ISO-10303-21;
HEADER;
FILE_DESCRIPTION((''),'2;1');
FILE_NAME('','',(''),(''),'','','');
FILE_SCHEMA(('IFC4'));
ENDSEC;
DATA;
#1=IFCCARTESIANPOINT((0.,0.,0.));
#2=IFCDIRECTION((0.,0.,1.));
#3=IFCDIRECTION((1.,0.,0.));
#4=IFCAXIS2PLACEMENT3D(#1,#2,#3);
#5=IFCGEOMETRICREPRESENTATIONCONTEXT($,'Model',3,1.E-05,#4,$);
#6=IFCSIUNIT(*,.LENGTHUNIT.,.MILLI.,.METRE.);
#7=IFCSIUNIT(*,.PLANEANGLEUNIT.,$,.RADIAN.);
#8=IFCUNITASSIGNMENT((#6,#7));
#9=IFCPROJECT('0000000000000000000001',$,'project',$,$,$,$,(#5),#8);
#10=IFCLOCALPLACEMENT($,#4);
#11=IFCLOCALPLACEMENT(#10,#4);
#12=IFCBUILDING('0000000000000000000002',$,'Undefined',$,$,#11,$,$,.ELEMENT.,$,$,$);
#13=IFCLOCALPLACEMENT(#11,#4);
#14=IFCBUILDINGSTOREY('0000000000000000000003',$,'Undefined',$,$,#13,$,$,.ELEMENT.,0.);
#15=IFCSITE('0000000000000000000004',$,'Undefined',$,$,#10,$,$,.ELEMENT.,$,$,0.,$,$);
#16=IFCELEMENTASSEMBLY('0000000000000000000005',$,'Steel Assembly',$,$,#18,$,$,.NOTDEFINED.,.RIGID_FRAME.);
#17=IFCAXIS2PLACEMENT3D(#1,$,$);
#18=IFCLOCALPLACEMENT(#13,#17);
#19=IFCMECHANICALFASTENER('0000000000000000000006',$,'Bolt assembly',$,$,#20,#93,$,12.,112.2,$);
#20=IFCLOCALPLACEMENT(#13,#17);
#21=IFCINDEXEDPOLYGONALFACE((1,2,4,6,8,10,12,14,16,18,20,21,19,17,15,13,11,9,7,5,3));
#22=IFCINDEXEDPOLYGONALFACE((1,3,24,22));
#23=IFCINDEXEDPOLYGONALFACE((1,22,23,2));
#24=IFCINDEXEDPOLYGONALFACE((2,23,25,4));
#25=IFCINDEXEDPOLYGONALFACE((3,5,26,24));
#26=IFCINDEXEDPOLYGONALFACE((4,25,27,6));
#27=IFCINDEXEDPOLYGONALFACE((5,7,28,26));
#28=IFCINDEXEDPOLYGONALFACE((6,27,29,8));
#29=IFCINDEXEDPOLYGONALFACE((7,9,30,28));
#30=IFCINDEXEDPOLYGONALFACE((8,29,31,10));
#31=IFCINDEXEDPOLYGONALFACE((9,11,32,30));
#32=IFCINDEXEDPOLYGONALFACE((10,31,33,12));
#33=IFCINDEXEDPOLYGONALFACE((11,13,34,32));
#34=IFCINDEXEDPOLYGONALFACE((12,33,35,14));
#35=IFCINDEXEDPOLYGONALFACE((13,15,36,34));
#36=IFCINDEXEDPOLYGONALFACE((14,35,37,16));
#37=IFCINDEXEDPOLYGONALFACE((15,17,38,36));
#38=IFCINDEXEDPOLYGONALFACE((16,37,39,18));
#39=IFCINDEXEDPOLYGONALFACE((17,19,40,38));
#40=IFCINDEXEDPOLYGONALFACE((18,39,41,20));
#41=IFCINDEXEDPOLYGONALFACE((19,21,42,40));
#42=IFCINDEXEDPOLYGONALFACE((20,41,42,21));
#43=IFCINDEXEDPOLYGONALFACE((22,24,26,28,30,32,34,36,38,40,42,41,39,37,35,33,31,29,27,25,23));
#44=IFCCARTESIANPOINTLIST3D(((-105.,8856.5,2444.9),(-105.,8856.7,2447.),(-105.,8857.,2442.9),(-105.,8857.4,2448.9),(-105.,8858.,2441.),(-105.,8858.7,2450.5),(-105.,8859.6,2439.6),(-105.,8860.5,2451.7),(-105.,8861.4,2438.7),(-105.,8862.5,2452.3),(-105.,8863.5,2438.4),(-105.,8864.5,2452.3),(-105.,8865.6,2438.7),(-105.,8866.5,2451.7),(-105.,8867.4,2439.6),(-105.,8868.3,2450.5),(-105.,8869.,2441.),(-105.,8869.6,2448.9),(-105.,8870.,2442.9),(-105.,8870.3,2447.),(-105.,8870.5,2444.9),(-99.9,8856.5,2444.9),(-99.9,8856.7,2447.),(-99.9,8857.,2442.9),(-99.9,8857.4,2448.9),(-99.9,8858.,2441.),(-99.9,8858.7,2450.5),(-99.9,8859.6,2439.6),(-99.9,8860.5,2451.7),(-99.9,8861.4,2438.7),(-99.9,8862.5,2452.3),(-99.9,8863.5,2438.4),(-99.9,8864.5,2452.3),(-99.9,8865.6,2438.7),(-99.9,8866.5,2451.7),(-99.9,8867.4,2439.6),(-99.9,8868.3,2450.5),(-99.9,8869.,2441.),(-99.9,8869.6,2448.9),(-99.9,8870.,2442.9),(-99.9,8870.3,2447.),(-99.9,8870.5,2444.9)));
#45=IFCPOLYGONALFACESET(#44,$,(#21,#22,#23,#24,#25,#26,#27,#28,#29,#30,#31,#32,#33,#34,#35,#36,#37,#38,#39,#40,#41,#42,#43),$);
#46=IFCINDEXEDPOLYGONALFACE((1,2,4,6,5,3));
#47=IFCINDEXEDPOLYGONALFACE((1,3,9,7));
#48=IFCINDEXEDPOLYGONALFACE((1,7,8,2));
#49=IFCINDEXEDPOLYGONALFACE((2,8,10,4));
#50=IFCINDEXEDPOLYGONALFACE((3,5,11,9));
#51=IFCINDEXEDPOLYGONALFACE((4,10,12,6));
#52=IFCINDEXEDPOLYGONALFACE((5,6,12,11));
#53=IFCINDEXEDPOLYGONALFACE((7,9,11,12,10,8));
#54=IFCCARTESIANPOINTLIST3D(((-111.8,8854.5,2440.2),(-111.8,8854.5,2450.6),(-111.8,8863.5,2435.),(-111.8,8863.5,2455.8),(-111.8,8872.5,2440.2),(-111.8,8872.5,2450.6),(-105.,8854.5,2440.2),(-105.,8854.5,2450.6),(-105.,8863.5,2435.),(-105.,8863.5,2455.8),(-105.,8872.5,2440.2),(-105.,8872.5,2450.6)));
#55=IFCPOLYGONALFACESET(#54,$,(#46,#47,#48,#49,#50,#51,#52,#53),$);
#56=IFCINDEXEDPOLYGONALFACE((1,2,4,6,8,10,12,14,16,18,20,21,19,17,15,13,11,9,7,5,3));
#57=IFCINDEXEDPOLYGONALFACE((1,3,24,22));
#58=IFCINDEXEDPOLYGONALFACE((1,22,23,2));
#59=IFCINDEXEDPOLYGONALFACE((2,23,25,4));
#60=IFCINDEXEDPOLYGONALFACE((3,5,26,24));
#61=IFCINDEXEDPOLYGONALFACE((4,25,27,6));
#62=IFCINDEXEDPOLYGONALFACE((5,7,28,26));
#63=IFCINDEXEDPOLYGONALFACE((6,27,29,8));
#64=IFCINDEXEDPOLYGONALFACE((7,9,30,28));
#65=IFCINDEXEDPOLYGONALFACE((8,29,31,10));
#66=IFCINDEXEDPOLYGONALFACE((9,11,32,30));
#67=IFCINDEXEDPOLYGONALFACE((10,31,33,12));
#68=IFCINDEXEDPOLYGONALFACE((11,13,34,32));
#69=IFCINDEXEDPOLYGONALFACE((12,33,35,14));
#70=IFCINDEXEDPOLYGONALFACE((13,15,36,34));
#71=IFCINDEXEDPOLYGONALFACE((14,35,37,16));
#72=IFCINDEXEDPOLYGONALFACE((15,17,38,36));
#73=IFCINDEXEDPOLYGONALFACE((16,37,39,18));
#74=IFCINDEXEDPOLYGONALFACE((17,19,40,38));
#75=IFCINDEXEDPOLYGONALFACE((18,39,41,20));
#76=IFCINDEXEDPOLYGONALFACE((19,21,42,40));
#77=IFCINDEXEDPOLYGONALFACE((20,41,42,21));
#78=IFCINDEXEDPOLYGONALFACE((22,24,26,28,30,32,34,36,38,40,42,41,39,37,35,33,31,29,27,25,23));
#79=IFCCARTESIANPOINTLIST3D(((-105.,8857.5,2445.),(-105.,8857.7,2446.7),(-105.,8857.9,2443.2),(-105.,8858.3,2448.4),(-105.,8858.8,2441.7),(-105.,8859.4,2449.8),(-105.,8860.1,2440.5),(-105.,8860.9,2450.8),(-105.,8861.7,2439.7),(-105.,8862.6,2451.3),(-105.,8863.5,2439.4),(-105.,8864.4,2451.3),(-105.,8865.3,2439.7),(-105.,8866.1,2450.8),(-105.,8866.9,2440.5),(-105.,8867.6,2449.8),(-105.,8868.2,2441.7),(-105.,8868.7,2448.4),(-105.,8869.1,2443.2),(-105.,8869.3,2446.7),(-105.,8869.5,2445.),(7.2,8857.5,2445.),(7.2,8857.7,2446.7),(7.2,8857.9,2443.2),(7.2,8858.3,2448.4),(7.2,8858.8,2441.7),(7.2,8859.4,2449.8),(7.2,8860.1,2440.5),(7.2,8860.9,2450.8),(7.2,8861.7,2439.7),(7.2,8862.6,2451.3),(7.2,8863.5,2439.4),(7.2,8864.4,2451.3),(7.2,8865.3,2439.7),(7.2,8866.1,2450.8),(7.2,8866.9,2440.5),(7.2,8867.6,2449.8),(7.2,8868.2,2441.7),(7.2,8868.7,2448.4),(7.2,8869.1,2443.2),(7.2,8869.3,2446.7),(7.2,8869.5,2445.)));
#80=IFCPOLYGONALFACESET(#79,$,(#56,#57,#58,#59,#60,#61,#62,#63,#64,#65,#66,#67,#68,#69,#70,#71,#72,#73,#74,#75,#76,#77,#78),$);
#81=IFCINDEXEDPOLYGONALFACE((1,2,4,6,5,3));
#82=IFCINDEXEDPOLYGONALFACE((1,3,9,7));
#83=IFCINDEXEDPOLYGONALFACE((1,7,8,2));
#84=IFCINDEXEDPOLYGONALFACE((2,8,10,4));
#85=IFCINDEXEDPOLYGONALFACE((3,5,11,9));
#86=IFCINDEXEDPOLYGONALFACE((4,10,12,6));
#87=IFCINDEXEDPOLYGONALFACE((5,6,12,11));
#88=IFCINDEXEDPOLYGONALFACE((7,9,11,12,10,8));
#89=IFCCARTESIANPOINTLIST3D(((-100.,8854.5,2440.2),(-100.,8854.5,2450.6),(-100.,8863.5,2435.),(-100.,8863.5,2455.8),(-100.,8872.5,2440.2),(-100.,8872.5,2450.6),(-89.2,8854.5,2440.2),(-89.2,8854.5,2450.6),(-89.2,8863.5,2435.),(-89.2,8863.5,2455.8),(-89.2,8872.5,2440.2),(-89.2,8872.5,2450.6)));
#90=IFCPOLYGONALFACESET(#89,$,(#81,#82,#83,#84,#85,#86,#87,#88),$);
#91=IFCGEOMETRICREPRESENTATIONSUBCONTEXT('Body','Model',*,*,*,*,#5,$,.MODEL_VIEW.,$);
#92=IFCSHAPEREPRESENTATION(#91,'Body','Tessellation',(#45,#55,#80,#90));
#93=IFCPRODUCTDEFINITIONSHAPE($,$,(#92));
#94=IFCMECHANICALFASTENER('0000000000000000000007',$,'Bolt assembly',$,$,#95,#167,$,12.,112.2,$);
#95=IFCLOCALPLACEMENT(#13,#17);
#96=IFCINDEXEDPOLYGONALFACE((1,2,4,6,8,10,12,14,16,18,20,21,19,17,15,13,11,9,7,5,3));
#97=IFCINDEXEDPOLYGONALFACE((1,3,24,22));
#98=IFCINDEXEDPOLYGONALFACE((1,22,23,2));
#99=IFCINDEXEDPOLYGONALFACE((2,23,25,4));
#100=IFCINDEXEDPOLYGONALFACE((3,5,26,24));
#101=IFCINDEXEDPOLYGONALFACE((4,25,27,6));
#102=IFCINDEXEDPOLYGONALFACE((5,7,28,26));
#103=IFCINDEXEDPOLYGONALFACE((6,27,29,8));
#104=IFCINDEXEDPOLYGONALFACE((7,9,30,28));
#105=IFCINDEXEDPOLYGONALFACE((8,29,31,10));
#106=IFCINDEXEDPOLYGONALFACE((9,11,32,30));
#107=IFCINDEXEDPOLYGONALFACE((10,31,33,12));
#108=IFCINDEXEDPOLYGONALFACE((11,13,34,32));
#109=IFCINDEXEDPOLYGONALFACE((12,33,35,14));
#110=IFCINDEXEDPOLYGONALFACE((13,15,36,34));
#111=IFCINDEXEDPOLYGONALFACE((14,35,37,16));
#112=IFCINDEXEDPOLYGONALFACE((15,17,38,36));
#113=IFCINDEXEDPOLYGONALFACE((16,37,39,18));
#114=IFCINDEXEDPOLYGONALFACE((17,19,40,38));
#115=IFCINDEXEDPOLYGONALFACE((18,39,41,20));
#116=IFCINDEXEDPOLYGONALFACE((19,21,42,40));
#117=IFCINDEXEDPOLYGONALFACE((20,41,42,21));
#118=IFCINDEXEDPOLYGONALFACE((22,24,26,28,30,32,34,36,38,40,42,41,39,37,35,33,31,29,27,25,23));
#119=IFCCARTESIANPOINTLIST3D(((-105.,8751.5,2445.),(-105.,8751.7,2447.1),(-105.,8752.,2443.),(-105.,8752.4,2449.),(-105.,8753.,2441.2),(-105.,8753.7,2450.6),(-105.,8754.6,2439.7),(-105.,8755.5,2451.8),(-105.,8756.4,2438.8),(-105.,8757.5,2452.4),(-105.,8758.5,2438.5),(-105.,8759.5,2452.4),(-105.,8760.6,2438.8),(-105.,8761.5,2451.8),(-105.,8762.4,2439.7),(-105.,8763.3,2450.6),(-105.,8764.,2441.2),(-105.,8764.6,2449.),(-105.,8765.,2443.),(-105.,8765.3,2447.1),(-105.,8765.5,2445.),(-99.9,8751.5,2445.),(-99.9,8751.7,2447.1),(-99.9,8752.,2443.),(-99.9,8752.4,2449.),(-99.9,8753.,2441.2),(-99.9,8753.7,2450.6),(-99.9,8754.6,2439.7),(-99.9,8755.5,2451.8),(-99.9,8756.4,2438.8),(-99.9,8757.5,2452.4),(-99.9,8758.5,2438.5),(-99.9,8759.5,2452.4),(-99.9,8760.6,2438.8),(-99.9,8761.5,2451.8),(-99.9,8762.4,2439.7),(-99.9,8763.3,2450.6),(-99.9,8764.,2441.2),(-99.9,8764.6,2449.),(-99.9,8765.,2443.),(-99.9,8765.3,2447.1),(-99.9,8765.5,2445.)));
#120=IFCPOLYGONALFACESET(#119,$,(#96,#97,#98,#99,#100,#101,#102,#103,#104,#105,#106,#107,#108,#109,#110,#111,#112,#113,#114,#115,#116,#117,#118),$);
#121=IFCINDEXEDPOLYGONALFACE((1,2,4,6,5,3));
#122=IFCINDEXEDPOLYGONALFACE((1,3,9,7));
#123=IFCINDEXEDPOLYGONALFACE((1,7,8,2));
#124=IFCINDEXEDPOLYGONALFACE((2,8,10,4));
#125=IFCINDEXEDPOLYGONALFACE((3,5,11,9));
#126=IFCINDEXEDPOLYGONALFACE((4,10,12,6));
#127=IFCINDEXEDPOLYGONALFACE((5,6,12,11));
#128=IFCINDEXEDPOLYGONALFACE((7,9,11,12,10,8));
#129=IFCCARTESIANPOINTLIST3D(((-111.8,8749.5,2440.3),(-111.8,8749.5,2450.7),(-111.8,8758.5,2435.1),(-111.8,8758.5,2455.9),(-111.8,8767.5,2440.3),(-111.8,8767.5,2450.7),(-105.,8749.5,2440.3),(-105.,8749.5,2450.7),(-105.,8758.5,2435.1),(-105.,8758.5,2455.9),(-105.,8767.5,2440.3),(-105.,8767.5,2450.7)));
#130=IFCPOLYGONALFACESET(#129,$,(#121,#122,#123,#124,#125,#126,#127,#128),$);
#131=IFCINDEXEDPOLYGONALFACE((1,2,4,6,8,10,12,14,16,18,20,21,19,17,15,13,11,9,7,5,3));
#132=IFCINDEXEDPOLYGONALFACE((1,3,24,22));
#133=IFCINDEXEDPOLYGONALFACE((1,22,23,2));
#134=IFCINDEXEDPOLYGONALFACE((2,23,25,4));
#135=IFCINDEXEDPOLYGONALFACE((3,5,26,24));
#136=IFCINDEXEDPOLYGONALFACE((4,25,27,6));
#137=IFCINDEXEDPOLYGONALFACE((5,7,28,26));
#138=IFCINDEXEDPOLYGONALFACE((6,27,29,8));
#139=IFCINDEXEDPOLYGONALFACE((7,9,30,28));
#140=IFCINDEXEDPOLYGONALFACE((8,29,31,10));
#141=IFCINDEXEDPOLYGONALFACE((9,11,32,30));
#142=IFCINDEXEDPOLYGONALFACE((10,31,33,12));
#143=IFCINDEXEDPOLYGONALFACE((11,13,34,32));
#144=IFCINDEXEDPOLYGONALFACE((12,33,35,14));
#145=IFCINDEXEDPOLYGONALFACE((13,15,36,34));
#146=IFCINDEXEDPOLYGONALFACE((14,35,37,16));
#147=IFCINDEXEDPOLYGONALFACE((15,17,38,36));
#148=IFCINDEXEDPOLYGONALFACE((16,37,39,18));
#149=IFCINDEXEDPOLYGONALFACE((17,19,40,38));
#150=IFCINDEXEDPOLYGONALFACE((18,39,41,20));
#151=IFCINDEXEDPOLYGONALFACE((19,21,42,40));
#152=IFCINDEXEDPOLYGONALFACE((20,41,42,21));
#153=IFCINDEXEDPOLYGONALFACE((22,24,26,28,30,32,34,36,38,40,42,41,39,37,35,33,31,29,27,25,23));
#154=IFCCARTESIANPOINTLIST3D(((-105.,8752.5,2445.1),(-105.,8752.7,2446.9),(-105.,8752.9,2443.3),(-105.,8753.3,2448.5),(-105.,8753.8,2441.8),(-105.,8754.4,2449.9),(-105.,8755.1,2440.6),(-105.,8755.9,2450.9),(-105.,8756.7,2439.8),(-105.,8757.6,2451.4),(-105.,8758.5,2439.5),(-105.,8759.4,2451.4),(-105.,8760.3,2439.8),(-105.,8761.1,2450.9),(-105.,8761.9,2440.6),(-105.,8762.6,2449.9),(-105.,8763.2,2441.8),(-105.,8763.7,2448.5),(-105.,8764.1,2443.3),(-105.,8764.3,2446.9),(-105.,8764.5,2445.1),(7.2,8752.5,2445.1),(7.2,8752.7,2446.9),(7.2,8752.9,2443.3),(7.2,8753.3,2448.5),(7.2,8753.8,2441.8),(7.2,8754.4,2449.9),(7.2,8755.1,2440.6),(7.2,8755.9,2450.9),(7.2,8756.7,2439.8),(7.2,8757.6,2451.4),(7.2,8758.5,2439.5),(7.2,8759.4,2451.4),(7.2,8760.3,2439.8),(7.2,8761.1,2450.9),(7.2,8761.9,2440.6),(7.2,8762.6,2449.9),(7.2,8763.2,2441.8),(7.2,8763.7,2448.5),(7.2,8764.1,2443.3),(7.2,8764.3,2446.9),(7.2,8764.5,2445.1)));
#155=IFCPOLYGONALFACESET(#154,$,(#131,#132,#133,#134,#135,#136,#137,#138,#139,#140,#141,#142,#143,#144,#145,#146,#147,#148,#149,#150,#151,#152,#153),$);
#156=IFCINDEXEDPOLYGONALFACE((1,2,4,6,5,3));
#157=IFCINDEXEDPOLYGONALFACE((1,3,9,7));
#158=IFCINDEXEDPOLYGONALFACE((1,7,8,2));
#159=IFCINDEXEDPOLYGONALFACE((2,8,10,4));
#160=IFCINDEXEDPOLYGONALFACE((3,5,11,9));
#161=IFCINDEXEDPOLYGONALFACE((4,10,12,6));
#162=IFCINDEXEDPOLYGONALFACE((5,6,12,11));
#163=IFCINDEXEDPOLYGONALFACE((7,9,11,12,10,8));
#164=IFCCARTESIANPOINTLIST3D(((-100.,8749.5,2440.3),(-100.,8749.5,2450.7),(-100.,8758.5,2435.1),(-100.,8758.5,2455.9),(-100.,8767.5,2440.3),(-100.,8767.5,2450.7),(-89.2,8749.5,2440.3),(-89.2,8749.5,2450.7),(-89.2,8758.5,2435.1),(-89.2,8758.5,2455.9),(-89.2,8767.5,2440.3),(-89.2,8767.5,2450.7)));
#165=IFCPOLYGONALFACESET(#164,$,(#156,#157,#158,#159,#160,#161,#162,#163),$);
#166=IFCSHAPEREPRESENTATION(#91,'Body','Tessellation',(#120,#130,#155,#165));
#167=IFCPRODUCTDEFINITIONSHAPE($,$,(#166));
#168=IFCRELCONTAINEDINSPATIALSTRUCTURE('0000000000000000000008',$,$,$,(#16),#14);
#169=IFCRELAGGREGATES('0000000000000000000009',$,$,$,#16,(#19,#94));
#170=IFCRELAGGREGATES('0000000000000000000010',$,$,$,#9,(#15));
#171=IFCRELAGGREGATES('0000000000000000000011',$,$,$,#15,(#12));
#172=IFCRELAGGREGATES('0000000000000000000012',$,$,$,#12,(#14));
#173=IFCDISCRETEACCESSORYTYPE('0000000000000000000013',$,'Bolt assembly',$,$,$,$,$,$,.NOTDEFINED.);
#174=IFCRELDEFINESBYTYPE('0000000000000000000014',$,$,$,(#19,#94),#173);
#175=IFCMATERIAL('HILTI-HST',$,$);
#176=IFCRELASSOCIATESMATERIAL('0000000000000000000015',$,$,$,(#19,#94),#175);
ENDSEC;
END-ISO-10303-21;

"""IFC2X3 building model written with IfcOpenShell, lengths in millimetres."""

from ifc_helpers import new_model, si_unit, frame, origin_with_axes, origin_2d_with_axis, place, context, subcontext, project, spatial, polyline, circle, outline, extrude, source, transform, mapped, material, type_object, element, aggregate, save


model = new_model("IFC2X3")

# Units and contexts
model_context = context("Model", 3, precision=1e-05, world=origin_with_axes())
body_context = subcontext(model_context, "Body", "Model", "MODEL_VIEW")
ifc_project = project(units=[si_unit("LENGTHUNIT", "METRE", prefix="MILLI"), si_unit("PLANEANGLEUNIT", "RADIAN")], contexts=[model_context])

# Site, building, storey
site_placement = place(None, origin_with_axes())
site = spatial("IfcSite", under=ifc_project, at=site_placement, Name="Undefined", CompositionType="ELEMENT", RefElevation=0.0)
building_placement = place(site_placement, origin_with_axes())
building = spatial("IfcBuilding", under=site, at=building_placement, Name="Undefined", CompositionType="ELEMENT")
storey_placement = place(building_placement, origin_with_axes())
storey = spatial("IfcBuildingStorey", under=building, at=storey_placement, Name="Undefined", CompositionType="ELEMENT", Elevation=0.0)

# Element assembly
assembly_1_placement = place(storey_placement, origin_with_axes())
assembly_1 = element("IfcElementAssembly", 1, at=assembly_1_placement, inside=storey, Name="Steel Assembly", AssemblyPlace="NOTDEFINED", PredefinedType="RIGID_FRAME")

# Shared definitions
discrete_accessory_type_1 = type_object("IfcDiscreteAccessoryType", Name="Bolt assembly")

# Mechanical fasteners
ifc_material_1 = material(Name="HILTI-HST")
shared_shape_1 = source(origin_with_axes(), body_context, "Body", "SweptSolid", [
    extrude(circle(Radius=7.0, at=origin_2d_with_axis()), frame((0.0, -5.0, 0.0), z_axis=(0.0, 1.0, 0.0), x_axis=(1.0, 0.0, 0.0)), (0.0, 0.0, 1.0), 5.1),
    extrude(outline(polyline([(10.4, 0.0), (5.2, 9.0), (-5.2, 9.0), (-10.4, 0.0), (-5.2, -9.0), (5.2, -9.0), (10.4, 0.0)])), frame((0.0, -11.8, 0.0), z_axis=(0.0, 1.0, 0.0), x_axis=(1.0, 0.0, 0.0)), (0.0, 0.0, 1.0), 6.8),
    extrude(circle(Radius=6.0, at=origin_2d_with_axis()), frame((0.0, -5.0, 0.0), z_axis=(0.0, 1.0, 0.0), x_axis=(1.0, 0.0, 0.0)), (0.0, 0.0, 1.0), 112.2),
    extrude(outline(polyline([(10.4, 0.0), (5.2, 9.0), (-5.2, 9.0), (-10.4, 0.0), (-5.2, -9.0), (5.2, -9.0), (10.4, 0.0)])), frame((0.0, 0.0, 0.0), z_axis=(0.0, 1.0, 0.0), x_axis=(1.0, 0.0, 0.0)), (0.0, 0.0, 1.0), 10.8),
])
mechanical_fastener_1_placement = place(assembly_1_placement, frame((-100.0, 8863.5, 2445.4), z_axis=(0.0, -1.0, 0.0), x_axis=(0.0, 0.0, -1.0)))
mechanical_fastener_1 = element("IfcMechanicalFastener", 2, at=mechanical_fastener_1_placement, type_object=discrete_accessory_type_1, material=ifc_material_1, Name="Bolt assembly", NominalDiameter=12.0, NominalLength=112.2, context=body_context, shape_type="MappedRepresentation", body=[
    mapped(shared_shape_1, transform((0.0, 0.0, 0.0))),
])
mechanical_fastener_2_placement = place(assembly_1_placement, frame((-100.0, 8758.5, 2445.5), z_axis=(0.0, -1.0, 0.0), x_axis=(0.0, 0.0, -1.0)))
mechanical_fastener_2 = element("IfcMechanicalFastener", 3, at=mechanical_fastener_2_placement, type_object=discrete_accessory_type_1, material=ifc_material_1, Name="Bolt assembly", NominalDiameter=12.0, NominalLength=112.2, context=body_context, shape_type="MappedRepresentation", body=[
    mapped(shared_shape_1, transform((0.0, 0.0, 0.0))),
])
aggregate(assembly_1, [mechanical_fastener_1, mechanical_fastener_2])

save(model, "model.ifc")
